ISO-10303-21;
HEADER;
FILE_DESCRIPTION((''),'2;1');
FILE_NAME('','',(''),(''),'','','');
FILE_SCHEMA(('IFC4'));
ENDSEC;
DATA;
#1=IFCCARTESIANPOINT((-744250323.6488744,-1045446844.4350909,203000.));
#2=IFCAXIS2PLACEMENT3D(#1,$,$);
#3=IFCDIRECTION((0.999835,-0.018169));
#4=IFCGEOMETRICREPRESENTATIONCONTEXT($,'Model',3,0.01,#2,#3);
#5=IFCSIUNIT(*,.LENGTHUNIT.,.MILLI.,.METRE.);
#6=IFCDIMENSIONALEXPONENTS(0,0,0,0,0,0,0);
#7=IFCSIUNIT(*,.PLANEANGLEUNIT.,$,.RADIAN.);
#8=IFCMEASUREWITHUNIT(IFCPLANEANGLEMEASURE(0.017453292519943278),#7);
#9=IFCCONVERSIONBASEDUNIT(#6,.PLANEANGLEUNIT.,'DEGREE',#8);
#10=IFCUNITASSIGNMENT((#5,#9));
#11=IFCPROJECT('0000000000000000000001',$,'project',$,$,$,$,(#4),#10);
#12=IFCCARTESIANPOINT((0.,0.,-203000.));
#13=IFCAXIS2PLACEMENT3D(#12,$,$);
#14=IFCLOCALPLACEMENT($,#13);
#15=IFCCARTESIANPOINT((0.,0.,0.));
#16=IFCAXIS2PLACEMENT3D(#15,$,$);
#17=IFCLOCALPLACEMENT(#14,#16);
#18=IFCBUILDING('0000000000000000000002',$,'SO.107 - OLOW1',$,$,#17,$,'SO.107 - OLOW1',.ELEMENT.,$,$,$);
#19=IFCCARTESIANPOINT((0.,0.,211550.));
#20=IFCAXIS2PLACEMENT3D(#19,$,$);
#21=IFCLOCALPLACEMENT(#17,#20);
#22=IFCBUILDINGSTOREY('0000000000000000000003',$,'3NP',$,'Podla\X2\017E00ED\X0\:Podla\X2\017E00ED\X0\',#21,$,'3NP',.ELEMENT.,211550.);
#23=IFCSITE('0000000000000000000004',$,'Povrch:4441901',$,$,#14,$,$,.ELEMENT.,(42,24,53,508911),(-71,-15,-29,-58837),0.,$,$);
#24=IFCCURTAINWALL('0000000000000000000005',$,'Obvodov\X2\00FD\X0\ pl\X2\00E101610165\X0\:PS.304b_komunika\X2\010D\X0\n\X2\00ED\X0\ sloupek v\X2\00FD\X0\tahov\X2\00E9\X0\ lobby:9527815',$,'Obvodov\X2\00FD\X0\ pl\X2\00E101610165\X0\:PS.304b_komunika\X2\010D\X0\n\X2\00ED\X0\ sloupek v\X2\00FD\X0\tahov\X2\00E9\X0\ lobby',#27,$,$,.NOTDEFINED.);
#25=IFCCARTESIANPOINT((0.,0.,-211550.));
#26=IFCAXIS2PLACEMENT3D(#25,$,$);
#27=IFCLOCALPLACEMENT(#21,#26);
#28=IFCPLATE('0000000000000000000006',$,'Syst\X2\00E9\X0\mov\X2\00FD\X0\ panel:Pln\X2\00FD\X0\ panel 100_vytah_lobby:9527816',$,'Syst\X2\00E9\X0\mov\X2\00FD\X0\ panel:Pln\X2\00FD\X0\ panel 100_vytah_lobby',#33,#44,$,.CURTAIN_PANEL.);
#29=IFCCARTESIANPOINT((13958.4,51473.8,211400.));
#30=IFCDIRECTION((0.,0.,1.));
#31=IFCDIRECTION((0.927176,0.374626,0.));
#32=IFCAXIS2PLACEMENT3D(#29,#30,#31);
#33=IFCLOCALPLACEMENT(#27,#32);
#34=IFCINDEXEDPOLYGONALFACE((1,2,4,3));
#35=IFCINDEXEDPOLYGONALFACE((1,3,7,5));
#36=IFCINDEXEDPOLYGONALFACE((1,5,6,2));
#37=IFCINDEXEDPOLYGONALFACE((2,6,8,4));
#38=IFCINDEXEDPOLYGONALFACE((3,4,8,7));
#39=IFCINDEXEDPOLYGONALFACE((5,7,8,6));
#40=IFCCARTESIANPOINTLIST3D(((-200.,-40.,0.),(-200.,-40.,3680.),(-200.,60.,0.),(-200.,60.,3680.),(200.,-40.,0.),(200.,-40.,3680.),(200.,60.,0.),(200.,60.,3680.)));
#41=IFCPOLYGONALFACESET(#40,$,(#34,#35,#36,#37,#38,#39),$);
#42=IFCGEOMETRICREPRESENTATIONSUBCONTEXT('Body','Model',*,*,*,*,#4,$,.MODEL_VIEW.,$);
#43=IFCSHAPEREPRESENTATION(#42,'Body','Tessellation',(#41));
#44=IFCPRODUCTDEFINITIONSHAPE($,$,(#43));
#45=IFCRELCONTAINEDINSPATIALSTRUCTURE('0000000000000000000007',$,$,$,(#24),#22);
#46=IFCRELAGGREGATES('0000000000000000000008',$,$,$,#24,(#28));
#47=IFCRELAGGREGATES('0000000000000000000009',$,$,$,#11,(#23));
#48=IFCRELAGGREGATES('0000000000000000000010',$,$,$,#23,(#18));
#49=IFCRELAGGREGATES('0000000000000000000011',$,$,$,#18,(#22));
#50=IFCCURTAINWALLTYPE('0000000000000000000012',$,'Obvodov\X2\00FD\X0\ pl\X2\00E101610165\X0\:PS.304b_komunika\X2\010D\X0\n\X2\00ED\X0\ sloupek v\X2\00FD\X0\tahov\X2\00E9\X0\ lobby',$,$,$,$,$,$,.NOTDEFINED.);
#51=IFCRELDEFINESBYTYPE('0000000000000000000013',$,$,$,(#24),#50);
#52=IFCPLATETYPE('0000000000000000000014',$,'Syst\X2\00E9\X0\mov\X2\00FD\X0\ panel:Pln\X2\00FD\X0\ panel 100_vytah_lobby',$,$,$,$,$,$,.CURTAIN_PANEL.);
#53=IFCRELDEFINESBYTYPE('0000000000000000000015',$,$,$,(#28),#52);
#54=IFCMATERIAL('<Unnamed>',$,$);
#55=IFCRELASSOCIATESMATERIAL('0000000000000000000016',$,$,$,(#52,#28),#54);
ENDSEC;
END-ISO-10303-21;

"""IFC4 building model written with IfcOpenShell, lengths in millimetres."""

from ifc_helpers import new_model, entity, si_unit, converted_unit, direction, frame, origin, place, context, subcontext, project, spatial, indexed_curve, outline, extrude, source, transform, mapped, material, type_object, type_shapes, element, aggregate, save


model = new_model("IFC4")

# Units and contexts
model_context = context("Model", 3, precision=0.01, world=frame((-744250323.6488744, -1045446844.4350909, 203000.0)), true_north=direction((0.999835, -0.018169)))
body_context = subcontext(model_context, "Body", "Model", "MODEL_VIEW")
ifc_project = project(units=[si_unit("LENGTHUNIT", "METRE", prefix="MILLI"), converted_unit("PLANEANGLEUNIT", "DEGREE", entity("IfcPlaneAngleMeasure", 0.017453292519943278), si_unit("PLANEANGLEUNIT", "RADIAN"), dimensions=[0, 0, 0, 0, 0, 0, 0])], contexts=[model_context])

# Site, building, storey
site_placement = place(None, frame((0.0, 0.0, -203000.0)))
site = spatial("IfcSite", under=ifc_project, at=site_placement, Name="Povrch:4441901", CompositionType="ELEMENT", RefLatitude=(42, 24, 53, 508911), RefLongitude=(-71, -15, -29, -58837), RefElevation=0.0)
building_placement = place(site_placement, origin())
building = spatial("IfcBuilding", under=site, at=building_placement, Name="SO.107 - OLOW1", LongName="SO.107 - OLOW1", CompositionType="ELEMENT")
storey_placement = place(building_placement, frame((0.0, 0.0, 211550.0)))
storey = spatial("IfcBuildingStorey", under=building, at=storey_placement, Name="3NP", ObjectType="Podlaží:Podlaží", LongName="3NP", CompositionType="ELEMENT", Elevation=211550.0)

# Shared definitions
ifc_material_1 = material(Name="<Unnamed>")

# Curtain wall, plate
curtain_wall_type_1 = type_object("IfcCurtainWallType", Name="Obvodový plášť:PS.304b_komunikační sloupek výtahové lobby", PredefinedType="NOTDEFINED")
curtain_wall_1_placement = place(storey_placement, frame((0.0, 0.0, -211550.0)))
curtain_wall_1 = element("IfcCurtainWall", 1, at=curtain_wall_1_placement, inside=storey, type_object=curtain_wall_type_1, Name="Obvodový plášť:PS.304b_komunikační sloupek výtahové lobby:9527815", ObjectType="Obvodový plášť:PS.304b_komunikační sloupek výtahové lobby", PredefinedType="NOTDEFINED")
plate_type_1 = type_object("IfcPlateType", Name="Systémový panel:Plný panel 100_vytah_lobby", PredefinedType="CURTAIN_PANEL", material=ifc_material_1)
shared_shape_1 = source(origin(), body_context, "Body", "SweptSolid", [
    extrude(outline(indexed_curve([(-50.0, -200.0), (50.0, -200.0), (50.0, 200.0), (-50.0, 200.0), (-50.0, -200.0)], self_intersect=False)), frame((0.0, 10.0, 0.0), z_axis=(0.0, 0.0, 1.0), x_axis=(0.0, 1.0, 0.0)), (0.0, 0.0, 1.0), 3680.0),
])
type_shapes(plate_type_1, [shared_shape_1])
plate_1_placement = place(curtain_wall_1_placement, frame((13958.4, 51473.8, 211400.0), z_axis=(0.0, 0.0, 1.0), x_axis=(0.927176, 0.374626, 0.0)))
plate_1 = element("IfcPlate", 2, at=plate_1_placement, type_object=plate_type_1, material=ifc_material_1, Name="Systémový panel:Plný panel 100_vytah_lobby:9527816", ObjectType="Systémový panel:Plný panel 100_vytah_lobby", PredefinedType="CURTAIN_PANEL", context=body_context, shape_type="MappedRepresentation", body=[
    mapped(shared_shape_1, transform((0.0, 0.0, 0.0), scale=1.0)),
])
aggregate(curtain_wall_1, [plate_1])

save(model, "model.ifc")
